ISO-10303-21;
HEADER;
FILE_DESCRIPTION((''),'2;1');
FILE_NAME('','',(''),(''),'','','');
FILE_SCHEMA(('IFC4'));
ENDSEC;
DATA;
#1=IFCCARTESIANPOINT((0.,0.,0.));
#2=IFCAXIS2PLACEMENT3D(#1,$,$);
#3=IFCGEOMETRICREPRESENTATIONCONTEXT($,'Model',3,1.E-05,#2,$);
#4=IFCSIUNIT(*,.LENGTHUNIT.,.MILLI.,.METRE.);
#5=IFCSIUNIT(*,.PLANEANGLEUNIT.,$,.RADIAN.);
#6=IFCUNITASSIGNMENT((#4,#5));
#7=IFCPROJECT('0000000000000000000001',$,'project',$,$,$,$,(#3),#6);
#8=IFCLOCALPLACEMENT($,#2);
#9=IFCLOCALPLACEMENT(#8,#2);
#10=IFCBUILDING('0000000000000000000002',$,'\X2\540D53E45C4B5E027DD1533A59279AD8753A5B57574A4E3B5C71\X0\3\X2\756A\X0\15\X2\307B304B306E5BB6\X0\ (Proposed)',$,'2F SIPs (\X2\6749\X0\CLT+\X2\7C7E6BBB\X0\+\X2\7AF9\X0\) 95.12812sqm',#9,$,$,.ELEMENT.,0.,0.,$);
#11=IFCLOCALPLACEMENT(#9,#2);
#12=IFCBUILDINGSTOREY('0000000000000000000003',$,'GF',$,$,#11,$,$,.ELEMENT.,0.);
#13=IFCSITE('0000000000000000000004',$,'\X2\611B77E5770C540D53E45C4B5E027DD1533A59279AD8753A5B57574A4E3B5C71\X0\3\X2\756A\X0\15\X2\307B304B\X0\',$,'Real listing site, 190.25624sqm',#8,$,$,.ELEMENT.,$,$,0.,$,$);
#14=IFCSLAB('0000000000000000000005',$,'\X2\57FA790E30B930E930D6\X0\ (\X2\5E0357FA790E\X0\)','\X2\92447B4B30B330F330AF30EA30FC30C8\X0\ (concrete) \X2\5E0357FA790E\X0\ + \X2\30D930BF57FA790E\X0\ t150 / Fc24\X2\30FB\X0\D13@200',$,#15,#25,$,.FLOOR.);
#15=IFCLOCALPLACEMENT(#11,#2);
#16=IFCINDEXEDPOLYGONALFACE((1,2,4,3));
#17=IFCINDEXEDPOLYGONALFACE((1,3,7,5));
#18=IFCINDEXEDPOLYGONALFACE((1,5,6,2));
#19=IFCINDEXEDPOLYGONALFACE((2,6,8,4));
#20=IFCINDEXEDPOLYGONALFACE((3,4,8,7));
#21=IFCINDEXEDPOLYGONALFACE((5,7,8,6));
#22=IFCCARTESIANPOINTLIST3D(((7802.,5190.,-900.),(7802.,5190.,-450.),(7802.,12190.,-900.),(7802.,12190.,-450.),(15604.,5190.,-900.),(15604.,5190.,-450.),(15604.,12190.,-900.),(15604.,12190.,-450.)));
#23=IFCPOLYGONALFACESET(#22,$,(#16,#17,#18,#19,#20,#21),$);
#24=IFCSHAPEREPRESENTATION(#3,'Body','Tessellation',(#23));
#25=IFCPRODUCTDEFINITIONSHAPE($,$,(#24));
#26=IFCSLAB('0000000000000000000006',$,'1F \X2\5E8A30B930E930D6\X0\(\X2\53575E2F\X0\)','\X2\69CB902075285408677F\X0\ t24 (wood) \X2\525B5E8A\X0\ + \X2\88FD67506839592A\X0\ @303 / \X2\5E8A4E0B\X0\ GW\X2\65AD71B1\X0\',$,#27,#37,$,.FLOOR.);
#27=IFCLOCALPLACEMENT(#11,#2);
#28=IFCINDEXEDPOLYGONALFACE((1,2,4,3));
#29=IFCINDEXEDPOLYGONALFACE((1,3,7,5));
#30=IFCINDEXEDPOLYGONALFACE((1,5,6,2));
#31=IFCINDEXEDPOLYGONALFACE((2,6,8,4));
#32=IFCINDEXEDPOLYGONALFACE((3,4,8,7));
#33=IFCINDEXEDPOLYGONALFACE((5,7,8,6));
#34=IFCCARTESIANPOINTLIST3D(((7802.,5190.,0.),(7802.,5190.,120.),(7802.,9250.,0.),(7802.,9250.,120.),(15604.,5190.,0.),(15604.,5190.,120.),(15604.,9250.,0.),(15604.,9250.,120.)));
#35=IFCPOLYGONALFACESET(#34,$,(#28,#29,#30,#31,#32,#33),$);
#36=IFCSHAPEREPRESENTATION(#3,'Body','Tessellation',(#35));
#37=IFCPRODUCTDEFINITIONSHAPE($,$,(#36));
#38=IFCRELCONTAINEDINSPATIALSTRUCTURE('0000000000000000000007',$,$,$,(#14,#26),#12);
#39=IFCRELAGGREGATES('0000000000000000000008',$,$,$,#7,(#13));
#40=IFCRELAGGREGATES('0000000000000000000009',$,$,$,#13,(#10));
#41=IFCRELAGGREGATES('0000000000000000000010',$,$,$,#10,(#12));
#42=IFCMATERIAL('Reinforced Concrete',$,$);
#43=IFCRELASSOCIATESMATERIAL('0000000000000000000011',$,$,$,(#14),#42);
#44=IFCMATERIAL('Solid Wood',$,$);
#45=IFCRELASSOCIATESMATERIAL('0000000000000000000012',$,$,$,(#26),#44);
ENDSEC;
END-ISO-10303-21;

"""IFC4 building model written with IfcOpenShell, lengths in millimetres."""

from ifc_helpers import new_model, si_unit, frame, frame_2d, origin, place, context, project, spatial, rectangle, extrude, material, element, save


model = new_model("IFC4")

# Units and contexts
model_context = context("Model", 3, precision=1e-05, world=origin())
ifc_project = project(units=[si_unit("LENGTHUNIT", "METRE", prefix="MILLI"), si_unit("PLANEANGLEUNIT", "RADIAN")], contexts=[model_context])

# Site, building, storey
site_placement = place(None, origin())
site = spatial("IfcSite", under=ifc_project, at=site_placement, Name="愛知県名古屋市緑区大高町字坊主山3番15ほか", ObjectType="Real listing site, 190.25624sqm", CompositionType="ELEMENT", RefElevation=0.0)
building_placement = place(site_placement, origin())
building = spatial("IfcBuilding", under=site, at=building_placement, Name="名古屋市緑区大高町字坊主山3番15ほかの家 (Proposed)", ObjectType="2F SIPs (杉CLT+籾殻+竹) 95.12812sqm", CompositionType="ELEMENT", ElevationOfRefHeight=0.0, ElevationOfTerrain=0.0)
storey_placement = place(building_placement, origin())
storey = spatial("IfcBuildingStorey", under=building, at=storey_placement, Name="GF", CompositionType="ELEMENT", Elevation=0.0)

# Slabs
ifc_material_1 = material(Name="Reinforced Concrete")
slab_1_placement = place(storey_placement, frame((3901.0, 2595.0, -450.0)))
element("IfcSlab", 1, at=slab_1_placement, inside=storey, material=ifc_material_1, Name="基礎スラブ (布基礎)", Description="鉄筋コンクリート (concrete) 布基礎 + ベタ基礎 t150 / Fc24・D13@200", PredefinedType="FLOOR", context=model_context, shape_type="SweptSolid", body=[
    extrude(rectangle(XDim=7802.0, YDim=7000.0, at=frame_2d((3901.0, 3500.0))), frame((3901.0, 2595.0, -450.0)), (0.0, 0.0, 1.0), 450.0),
])
ifc_material_2 = material(Name="Solid Wood")
slab_2_placement = place(storey_placement, frame((3901.0, 2595.0, 0.0)))
element("IfcSlab", 2, at=slab_2_placement, inside=storey, material=ifc_material_2, Name="1F 床スラブ(南帯)", Description="構造用合板 t24 (wood) 剛床 + 製材根太 @303 / 床下 GW断熱", PredefinedType="FLOOR", context=model_context, shape_type="SweptSolid", body=[
    extrude(rectangle(XDim=7802.0, YDim=4060.0, at=frame_2d((3901.0, 2030.0))), frame((3901.0, 2595.0, 0.0)), (0.0, 0.0, 1.0), 120.0),
])

save(model, "model.ifc")
